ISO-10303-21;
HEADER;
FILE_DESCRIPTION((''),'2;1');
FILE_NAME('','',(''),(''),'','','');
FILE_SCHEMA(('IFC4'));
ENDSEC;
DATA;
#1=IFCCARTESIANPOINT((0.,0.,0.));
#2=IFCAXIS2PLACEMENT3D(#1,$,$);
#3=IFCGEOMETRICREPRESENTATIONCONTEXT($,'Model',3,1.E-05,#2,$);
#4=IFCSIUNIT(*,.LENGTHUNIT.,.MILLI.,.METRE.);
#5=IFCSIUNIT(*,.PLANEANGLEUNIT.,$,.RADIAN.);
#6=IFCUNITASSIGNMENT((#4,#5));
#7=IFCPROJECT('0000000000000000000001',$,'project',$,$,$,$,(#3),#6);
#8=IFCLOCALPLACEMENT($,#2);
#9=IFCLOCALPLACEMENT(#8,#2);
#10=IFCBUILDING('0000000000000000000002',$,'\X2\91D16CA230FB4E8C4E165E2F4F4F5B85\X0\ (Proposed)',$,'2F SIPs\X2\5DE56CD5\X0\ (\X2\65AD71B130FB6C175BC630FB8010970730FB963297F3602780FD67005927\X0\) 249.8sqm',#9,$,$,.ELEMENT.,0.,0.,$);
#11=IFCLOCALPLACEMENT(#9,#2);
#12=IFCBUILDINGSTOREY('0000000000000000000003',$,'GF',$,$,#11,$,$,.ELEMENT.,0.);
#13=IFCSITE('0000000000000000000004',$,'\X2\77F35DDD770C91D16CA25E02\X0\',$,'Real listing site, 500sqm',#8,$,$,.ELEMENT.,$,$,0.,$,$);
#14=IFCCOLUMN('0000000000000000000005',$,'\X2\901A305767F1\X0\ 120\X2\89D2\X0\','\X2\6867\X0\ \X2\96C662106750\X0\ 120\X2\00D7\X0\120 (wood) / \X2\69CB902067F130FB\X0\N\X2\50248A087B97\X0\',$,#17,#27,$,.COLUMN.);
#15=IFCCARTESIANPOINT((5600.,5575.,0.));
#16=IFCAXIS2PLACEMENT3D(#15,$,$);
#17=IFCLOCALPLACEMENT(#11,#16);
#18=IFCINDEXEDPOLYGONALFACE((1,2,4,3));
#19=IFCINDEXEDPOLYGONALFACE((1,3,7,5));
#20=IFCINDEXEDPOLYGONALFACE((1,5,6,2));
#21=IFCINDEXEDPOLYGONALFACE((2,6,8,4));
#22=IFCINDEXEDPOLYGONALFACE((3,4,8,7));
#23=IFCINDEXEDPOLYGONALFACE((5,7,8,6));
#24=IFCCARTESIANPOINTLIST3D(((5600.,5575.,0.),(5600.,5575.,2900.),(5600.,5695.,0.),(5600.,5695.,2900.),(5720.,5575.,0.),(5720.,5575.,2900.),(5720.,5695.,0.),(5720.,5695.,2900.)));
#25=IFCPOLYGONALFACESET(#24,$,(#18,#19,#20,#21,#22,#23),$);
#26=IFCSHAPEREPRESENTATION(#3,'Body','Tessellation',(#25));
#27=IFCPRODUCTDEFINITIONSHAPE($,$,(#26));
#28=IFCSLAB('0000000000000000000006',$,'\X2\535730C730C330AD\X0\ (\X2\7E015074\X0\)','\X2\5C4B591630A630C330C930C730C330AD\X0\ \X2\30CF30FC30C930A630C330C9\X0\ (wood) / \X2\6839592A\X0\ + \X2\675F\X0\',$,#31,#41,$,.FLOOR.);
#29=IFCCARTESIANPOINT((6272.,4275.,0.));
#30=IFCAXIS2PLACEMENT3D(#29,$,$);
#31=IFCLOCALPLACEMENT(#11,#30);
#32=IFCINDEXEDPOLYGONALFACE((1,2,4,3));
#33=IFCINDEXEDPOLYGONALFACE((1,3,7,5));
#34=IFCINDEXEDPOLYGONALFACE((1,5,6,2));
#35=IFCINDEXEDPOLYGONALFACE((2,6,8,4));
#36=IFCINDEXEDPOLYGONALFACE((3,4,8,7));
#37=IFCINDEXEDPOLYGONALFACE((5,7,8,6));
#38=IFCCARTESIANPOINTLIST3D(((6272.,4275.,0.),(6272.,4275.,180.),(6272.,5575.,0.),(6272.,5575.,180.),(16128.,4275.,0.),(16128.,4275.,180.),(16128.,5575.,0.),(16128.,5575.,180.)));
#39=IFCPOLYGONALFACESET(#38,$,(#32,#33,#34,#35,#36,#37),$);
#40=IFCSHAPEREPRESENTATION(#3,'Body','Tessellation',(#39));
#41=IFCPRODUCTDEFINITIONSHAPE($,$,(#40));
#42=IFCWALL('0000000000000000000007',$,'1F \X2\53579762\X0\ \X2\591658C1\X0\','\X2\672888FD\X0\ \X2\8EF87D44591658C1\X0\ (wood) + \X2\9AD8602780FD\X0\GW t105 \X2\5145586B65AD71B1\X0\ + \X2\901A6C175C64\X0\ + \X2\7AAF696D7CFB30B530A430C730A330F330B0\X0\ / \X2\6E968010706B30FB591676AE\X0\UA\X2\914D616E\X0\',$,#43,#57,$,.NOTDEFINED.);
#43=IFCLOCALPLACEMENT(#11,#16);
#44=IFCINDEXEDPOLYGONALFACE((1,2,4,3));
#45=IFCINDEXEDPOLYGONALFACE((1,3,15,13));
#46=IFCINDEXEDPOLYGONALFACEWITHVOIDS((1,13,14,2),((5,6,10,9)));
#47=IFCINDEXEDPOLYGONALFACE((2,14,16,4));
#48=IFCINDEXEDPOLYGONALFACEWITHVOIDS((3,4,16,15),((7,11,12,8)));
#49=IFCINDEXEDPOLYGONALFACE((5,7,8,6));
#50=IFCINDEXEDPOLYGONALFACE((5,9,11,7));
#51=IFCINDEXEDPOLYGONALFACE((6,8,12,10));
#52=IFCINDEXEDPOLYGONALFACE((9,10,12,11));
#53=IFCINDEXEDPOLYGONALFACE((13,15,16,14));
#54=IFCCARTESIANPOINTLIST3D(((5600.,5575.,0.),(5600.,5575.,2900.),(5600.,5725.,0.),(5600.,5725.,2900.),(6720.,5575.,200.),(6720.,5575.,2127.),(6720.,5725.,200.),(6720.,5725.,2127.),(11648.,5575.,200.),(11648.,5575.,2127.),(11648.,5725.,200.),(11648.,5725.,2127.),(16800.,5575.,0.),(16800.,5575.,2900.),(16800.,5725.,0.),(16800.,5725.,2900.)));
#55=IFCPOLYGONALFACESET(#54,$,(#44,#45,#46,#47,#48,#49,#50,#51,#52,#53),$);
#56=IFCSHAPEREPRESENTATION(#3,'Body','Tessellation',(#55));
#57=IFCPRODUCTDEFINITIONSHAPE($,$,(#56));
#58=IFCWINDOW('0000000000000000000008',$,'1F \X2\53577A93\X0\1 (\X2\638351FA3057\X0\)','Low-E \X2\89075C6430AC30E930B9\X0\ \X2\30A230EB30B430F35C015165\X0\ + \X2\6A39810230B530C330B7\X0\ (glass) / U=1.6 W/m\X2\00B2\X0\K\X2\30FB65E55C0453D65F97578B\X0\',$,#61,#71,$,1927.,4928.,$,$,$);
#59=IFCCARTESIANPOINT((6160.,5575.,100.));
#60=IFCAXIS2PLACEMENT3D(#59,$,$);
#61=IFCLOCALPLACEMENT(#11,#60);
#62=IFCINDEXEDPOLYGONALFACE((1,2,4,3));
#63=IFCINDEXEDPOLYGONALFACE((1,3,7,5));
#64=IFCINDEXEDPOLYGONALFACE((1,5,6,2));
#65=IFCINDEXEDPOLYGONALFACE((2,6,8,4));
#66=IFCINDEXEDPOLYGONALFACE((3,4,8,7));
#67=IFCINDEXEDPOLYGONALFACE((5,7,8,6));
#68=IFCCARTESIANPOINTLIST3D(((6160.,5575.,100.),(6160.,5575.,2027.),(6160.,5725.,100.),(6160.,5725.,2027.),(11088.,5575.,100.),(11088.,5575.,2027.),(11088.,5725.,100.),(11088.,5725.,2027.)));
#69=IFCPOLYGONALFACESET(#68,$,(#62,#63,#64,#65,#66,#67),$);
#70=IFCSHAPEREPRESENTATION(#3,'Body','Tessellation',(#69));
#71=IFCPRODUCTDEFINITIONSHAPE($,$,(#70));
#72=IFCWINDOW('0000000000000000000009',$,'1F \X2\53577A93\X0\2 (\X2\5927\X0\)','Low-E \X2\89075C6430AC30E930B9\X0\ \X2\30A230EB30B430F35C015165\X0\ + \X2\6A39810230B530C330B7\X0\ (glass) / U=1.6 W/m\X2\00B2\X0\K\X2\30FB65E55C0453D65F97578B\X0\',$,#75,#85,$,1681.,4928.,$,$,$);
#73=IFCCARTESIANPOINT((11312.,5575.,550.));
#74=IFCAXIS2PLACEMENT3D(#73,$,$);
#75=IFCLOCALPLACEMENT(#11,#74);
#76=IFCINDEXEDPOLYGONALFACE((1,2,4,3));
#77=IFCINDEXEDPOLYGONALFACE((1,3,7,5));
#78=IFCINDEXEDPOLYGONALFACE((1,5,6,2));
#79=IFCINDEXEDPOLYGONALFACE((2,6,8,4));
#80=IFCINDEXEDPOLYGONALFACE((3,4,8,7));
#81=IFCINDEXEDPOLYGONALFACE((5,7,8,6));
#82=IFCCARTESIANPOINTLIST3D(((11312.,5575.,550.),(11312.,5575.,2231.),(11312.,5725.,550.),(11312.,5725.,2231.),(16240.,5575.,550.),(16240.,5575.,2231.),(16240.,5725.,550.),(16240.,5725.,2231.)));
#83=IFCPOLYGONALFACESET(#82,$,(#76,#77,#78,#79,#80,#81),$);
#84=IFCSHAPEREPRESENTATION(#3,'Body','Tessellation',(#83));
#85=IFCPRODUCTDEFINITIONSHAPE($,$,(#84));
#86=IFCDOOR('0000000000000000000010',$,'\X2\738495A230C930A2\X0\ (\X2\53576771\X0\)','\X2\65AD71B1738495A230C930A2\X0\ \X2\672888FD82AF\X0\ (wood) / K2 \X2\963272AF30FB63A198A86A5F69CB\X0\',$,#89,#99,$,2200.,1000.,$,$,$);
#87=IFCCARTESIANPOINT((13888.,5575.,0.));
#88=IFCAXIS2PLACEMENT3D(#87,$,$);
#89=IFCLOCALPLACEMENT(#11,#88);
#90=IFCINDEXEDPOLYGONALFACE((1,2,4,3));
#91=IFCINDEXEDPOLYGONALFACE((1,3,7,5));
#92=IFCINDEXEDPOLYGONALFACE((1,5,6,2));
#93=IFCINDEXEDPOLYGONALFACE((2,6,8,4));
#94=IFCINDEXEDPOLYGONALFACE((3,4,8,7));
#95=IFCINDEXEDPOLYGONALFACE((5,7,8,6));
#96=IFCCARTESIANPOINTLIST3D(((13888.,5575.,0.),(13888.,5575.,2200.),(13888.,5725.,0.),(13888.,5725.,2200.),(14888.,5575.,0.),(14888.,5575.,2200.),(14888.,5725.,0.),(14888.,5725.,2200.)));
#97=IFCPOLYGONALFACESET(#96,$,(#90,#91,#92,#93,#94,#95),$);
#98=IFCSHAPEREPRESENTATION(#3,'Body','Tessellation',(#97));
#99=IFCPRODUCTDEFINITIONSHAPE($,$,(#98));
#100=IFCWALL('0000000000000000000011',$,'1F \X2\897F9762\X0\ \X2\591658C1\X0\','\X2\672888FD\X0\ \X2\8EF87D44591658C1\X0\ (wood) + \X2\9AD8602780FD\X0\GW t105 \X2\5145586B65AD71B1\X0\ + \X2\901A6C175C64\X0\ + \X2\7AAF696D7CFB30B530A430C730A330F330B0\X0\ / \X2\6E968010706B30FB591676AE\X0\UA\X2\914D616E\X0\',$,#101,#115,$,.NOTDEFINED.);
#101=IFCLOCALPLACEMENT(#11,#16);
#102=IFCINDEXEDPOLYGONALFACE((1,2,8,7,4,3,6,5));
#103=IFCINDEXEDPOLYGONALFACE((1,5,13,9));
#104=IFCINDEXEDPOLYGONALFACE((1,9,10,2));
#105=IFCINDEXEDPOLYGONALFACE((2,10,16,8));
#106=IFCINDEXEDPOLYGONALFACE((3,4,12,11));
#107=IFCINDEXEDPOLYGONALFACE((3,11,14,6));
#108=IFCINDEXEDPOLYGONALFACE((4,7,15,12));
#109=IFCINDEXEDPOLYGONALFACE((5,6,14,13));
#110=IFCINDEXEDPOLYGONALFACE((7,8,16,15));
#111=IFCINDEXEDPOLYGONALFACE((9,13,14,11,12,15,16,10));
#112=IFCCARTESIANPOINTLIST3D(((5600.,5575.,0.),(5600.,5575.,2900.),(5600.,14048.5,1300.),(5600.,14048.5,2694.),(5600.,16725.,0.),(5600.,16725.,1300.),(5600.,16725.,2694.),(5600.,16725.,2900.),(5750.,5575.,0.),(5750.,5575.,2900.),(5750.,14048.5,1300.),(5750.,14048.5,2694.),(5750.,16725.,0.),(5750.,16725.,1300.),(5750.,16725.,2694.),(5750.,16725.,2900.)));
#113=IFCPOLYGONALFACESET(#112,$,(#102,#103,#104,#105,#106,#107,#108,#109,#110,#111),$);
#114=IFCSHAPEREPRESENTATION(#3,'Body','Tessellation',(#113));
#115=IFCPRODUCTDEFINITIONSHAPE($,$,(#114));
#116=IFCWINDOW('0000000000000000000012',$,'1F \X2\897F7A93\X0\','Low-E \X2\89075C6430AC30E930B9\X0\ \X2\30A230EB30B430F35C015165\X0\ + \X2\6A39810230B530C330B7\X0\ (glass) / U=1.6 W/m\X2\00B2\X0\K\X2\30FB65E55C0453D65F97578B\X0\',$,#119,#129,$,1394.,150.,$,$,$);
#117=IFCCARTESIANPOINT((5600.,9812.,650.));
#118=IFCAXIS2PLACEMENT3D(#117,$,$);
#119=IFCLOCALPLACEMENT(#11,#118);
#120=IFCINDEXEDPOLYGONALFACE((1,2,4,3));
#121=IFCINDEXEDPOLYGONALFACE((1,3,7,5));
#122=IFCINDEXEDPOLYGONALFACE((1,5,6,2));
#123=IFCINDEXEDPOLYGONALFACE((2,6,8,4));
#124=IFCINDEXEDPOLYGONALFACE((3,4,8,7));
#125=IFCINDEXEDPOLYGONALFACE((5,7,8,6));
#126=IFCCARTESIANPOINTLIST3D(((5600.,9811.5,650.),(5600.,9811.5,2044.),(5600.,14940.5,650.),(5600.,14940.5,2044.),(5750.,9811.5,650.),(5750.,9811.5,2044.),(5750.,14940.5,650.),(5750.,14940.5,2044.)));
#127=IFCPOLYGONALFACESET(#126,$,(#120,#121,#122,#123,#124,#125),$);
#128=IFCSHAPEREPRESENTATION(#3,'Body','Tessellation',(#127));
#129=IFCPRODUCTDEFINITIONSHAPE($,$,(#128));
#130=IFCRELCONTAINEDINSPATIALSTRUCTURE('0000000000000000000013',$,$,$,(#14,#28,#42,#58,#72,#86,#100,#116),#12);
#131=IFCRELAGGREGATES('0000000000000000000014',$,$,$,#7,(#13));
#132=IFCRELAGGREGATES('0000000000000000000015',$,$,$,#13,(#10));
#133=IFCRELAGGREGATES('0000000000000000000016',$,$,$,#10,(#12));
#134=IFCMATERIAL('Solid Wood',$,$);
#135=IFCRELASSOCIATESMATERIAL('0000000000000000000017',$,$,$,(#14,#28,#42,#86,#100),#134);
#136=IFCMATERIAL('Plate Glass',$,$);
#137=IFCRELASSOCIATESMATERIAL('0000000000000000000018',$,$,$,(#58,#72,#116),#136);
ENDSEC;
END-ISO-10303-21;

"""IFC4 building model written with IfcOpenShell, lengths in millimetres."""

from ifc_helpers import new_model, si_unit, frame, frame_2d, origin, place, context, project, spatial, rectangle, extrude, material, element, fill, save


model = new_model("IFC4")

# Units and contexts
model_context = context("Model", 3, precision=1e-05, world=origin())
ifc_project = project(units=[si_unit("LENGTHUNIT", "METRE", prefix="MILLI"), si_unit("PLANEANGLEUNIT", "RADIAN")], contexts=[model_context])

# Site, building, storey
site_placement = place(None, origin())
site = spatial("IfcSite", under=ifc_project, at=site_placement, Name="石川県金沢市", ObjectType="Real listing site, 500sqm", CompositionType="ELEMENT", RefElevation=0.0)
building_placement = place(site_placement, origin())
building = spatial("IfcBuilding", under=site, at=building_placement, Name="金沢・二世帯住宅 (Proposed)", ObjectType="2F SIPs工法 (断熱・気密・耐震・防音性能最大) 249.8sqm", CompositionType="ELEMENT", ElevationOfRefHeight=0.0, ElevationOfTerrain=0.0)
storey_placement = place(building_placement, origin())
storey = spatial("IfcBuildingStorey", under=building, at=storey_placement, Name="GF", CompositionType="ELEMENT", Elevation=0.0)

# Column
ifc_material_1 = material(Name="Solid Wood")
column_placement = place(storey_placement, frame((5600.0, 5575.0, 0.0)))
element("IfcColumn", 1, at=column_placement, inside=storey, material=ifc_material_1, Name="通し柱 120角", Description="桧 集成材 120×120 (wood) / 構造柱・N値計算", PredefinedType="COLUMN", context=model_context, shape_type="SweptSolid", body=[
    extrude(rectangle(XDim=120.0, YDim=120.0, at=frame_2d((60.0, 60.0))), frame((5600.0, 5575.0, 0.0)), (0.0, 0.0, 1.0), 2900.0),
])

# Slab
slab_1_placement = place(storey_placement, frame((6272.0, 4275.0, 0.0)))
element("IfcSlab", 2, at=slab_1_placement, inside=storey, material=ifc_material_1, Name="南デッキ (縁側)", Description="屋外ウッドデッキ ハードウッド (wood) / 根太 + 束", PredefinedType="FLOOR", context=model_context, shape_type="SweptSolid", body=[
    extrude(rectangle(XDim=9856.0, YDim=1300.0, at=frame_2d((4928.0, 650.0))), frame((6272.0, 4275.0, 0.0)), (0.0, 0.0, 1.0), 180.0),
])

# Wall, openings, windows, door
wall_1_placement = place(storey_placement, frame((5600.0, 5575.0, 0.0)))
wall_1 = element("IfcWall", 3, at=wall_1_placement, inside=storey, material=ifc_material_1, Name="1F 南面 外壁", Description="木製 軸組外壁 (wood) + 高性能GW t105 充填断熱 + 通気層 + 窯業系サイディング / 準耐火・外皮UA配慮", PredefinedType="NOTDEFINED", context=model_context, shape_type="SweptSolid", body=[
    extrude(rectangle(XDim=11200.0, YDim=150.0, at=frame_2d((5600.0, 75.0))), frame((5600.0, 5575.0, 0.0)), (0.0, 0.0, 1.0), 2900.0),
])
opening_1_placement = place(storey_placement, frame((6160.0, 5575.0, 100.0)))
opening_1 = element("IfcOpeningElement", 4, at=opening_1_placement, cuts=wall_1, PredefinedType="NOTDEFINED", context=model_context, shape_type="SweptSolid", body=[
    extrude(rectangle(XDim=4928.0, YDim=150.0, at=frame_2d((2464.0, 75.0))), frame((6160.0, 5575.0, 100.0)), (0.0, 0.0, 1.0), 1927.0),
])
opening_2_placement = place(storey_placement, frame((11312.0, 5575.0, 550.0)))
opening_2 = element("IfcOpeningElement", 5, at=opening_2_placement, cuts=wall_1, PredefinedType="NOTDEFINED", context=model_context, shape_type="SweptSolid", body=[
    extrude(rectangle(XDim=4928.0, YDim=150.0, at=frame_2d((2464.0, 75.0))), frame((11312.0, 5575.0, 550.0)), (0.0, 0.0, 1.0), 1681.0),
])
opening_3_placement = place(storey_placement, frame((13888.0, 5575.0, 0.0)))
opening_3 = element("IfcOpeningElement", 6, at=opening_3_placement, cuts=wall_1, PredefinedType="NOTDEFINED", context=model_context, shape_type="SweptSolid", body=[
    extrude(rectangle(XDim=1000.0, YDim=150.0, at=frame_2d((500.0, 75.0))), frame((13888.0, 5575.0, 0.0)), (0.0, 0.0, 1.0), 2200.0),
])
ifc_material_2 = material(Name="Plate Glass")
window_1_placement = place(storey_placement, frame((6160.0, 5575.0, 100.0)))
window_1 = element("IfcWindow", 7, at=window_1_placement, inside=storey, material=ifc_material_2, Name="1F 南窓1 (掃出し)", Description="Low-E 複層ガラス アルゴン封入 + 樹脂サッシ (glass) / U=1.6 W/m²K・日射取得型", OverallHeight=1927.0, OverallWidth=4928.0, context=model_context, shape_type="SweptSolid", body=[
    extrude(rectangle(XDim=4928.0, YDim=150.0, at=frame_2d((2464.0, 75.0))), frame((6160.0, 5575.0, 100.0)), (0.0, 0.0, 1.0), 1927.0),
])
fill(opening_1, window_1)
window_2_placement = place(storey_placement, frame((11312.0, 5575.0, 550.0)))
window_2 = element("IfcWindow", 8, at=window_2_placement, inside=storey, material=ifc_material_2, Name="1F 南窓2 (大)", Description="Low-E 複層ガラス アルゴン封入 + 樹脂サッシ (glass) / U=1.6 W/m²K・日射取得型", OverallHeight=1681.0, OverallWidth=4928.0, context=model_context, shape_type="SweptSolid", body=[
    extrude(rectangle(XDim=4928.0, YDim=150.0, at=frame_2d((2464.0, 75.0))), frame((11312.0, 5575.0, 550.0)), (0.0, 0.0, 1.0), 1681.0),
])
fill(opening_2, window_2)
door_placement = place(storey_placement, frame((13888.0, 5575.0, 0.0)))
door = element("IfcDoor", 9, at=door_placement, inside=storey, material=ifc_material_1, Name="玄関ドア (南東)", Description="断熱玄関ドア 木製芯 (wood) / K2 防犯・採風機構", OverallHeight=2200.0, OverallWidth=1000.0, context=model_context, shape_type="SweptSolid", body=[
    extrude(rectangle(XDim=1000.0, YDim=150.0, at=frame_2d((500.0, 75.0))), frame((13888.0, 5575.0, 0.0)), (0.0, 0.0, 1.0), 2200.0),
])
fill(opening_3, door)

# Wall, opening, window
wall_2_placement = place(storey_placement, frame((5600.0, 5575.0, 0.0)))
wall_2 = element("IfcWall", 10, at=wall_2_placement, inside=storey, material=ifc_material_1, Name="1F 西面 外壁", Description="木製 軸組外壁 (wood) + 高性能GW t105 充填断熱 + 通気層 + 窯業系サイディング / 準耐火・外皮UA配慮", PredefinedType="NOTDEFINED", context=model_context, shape_type="SweptSolid", body=[
    extrude(rectangle(XDim=150.0, YDim=11150.0, at=frame_2d((75.0, 5575.0))), frame((5600.0, 5575.0, 0.0)), (0.0, 0.0, 1.0), 2900.0),
])
opening_4_placement = place(storey_placement, frame((5600.0, 9812.0, 650.0)))
opening_4 = element("IfcOpeningElement", 11, at=opening_4_placement, cuts=wall_2, PredefinedType="NOTDEFINED", context=model_context, shape_type="SweptSolid", body=[
    extrude(rectangle(XDim=150.0, YDim=5129.0, at=frame_2d((75.0, 2564.0))), frame((5600.0, 9812.0, 650.0)), (0.0, 0.0, 1.0), 1394.0),
])
window_3_placement = place(storey_placement, frame((5600.0, 9812.0, 650.0)))
window_3 = element("IfcWindow", 12, at=window_3_placement, inside=storey, material=ifc_material_2, Name="1F 西窓", Description="Low-E 複層ガラス アルゴン封入 + 樹脂サッシ (glass) / U=1.6 W/m²K・日射取得型", OverallHeight=1394.0, OverallWidth=150.0, context=model_context, shape_type="SweptSolid", body=[
    extrude(rectangle(XDim=150.0, YDim=5129.0, at=frame_2d((75.0, 2564.0))), frame((5600.0, 9812.0, 650.0)), (0.0, 0.0, 1.0), 1394.0),
])
fill(opening_4, window_3)

save(model, "model.ifc")
